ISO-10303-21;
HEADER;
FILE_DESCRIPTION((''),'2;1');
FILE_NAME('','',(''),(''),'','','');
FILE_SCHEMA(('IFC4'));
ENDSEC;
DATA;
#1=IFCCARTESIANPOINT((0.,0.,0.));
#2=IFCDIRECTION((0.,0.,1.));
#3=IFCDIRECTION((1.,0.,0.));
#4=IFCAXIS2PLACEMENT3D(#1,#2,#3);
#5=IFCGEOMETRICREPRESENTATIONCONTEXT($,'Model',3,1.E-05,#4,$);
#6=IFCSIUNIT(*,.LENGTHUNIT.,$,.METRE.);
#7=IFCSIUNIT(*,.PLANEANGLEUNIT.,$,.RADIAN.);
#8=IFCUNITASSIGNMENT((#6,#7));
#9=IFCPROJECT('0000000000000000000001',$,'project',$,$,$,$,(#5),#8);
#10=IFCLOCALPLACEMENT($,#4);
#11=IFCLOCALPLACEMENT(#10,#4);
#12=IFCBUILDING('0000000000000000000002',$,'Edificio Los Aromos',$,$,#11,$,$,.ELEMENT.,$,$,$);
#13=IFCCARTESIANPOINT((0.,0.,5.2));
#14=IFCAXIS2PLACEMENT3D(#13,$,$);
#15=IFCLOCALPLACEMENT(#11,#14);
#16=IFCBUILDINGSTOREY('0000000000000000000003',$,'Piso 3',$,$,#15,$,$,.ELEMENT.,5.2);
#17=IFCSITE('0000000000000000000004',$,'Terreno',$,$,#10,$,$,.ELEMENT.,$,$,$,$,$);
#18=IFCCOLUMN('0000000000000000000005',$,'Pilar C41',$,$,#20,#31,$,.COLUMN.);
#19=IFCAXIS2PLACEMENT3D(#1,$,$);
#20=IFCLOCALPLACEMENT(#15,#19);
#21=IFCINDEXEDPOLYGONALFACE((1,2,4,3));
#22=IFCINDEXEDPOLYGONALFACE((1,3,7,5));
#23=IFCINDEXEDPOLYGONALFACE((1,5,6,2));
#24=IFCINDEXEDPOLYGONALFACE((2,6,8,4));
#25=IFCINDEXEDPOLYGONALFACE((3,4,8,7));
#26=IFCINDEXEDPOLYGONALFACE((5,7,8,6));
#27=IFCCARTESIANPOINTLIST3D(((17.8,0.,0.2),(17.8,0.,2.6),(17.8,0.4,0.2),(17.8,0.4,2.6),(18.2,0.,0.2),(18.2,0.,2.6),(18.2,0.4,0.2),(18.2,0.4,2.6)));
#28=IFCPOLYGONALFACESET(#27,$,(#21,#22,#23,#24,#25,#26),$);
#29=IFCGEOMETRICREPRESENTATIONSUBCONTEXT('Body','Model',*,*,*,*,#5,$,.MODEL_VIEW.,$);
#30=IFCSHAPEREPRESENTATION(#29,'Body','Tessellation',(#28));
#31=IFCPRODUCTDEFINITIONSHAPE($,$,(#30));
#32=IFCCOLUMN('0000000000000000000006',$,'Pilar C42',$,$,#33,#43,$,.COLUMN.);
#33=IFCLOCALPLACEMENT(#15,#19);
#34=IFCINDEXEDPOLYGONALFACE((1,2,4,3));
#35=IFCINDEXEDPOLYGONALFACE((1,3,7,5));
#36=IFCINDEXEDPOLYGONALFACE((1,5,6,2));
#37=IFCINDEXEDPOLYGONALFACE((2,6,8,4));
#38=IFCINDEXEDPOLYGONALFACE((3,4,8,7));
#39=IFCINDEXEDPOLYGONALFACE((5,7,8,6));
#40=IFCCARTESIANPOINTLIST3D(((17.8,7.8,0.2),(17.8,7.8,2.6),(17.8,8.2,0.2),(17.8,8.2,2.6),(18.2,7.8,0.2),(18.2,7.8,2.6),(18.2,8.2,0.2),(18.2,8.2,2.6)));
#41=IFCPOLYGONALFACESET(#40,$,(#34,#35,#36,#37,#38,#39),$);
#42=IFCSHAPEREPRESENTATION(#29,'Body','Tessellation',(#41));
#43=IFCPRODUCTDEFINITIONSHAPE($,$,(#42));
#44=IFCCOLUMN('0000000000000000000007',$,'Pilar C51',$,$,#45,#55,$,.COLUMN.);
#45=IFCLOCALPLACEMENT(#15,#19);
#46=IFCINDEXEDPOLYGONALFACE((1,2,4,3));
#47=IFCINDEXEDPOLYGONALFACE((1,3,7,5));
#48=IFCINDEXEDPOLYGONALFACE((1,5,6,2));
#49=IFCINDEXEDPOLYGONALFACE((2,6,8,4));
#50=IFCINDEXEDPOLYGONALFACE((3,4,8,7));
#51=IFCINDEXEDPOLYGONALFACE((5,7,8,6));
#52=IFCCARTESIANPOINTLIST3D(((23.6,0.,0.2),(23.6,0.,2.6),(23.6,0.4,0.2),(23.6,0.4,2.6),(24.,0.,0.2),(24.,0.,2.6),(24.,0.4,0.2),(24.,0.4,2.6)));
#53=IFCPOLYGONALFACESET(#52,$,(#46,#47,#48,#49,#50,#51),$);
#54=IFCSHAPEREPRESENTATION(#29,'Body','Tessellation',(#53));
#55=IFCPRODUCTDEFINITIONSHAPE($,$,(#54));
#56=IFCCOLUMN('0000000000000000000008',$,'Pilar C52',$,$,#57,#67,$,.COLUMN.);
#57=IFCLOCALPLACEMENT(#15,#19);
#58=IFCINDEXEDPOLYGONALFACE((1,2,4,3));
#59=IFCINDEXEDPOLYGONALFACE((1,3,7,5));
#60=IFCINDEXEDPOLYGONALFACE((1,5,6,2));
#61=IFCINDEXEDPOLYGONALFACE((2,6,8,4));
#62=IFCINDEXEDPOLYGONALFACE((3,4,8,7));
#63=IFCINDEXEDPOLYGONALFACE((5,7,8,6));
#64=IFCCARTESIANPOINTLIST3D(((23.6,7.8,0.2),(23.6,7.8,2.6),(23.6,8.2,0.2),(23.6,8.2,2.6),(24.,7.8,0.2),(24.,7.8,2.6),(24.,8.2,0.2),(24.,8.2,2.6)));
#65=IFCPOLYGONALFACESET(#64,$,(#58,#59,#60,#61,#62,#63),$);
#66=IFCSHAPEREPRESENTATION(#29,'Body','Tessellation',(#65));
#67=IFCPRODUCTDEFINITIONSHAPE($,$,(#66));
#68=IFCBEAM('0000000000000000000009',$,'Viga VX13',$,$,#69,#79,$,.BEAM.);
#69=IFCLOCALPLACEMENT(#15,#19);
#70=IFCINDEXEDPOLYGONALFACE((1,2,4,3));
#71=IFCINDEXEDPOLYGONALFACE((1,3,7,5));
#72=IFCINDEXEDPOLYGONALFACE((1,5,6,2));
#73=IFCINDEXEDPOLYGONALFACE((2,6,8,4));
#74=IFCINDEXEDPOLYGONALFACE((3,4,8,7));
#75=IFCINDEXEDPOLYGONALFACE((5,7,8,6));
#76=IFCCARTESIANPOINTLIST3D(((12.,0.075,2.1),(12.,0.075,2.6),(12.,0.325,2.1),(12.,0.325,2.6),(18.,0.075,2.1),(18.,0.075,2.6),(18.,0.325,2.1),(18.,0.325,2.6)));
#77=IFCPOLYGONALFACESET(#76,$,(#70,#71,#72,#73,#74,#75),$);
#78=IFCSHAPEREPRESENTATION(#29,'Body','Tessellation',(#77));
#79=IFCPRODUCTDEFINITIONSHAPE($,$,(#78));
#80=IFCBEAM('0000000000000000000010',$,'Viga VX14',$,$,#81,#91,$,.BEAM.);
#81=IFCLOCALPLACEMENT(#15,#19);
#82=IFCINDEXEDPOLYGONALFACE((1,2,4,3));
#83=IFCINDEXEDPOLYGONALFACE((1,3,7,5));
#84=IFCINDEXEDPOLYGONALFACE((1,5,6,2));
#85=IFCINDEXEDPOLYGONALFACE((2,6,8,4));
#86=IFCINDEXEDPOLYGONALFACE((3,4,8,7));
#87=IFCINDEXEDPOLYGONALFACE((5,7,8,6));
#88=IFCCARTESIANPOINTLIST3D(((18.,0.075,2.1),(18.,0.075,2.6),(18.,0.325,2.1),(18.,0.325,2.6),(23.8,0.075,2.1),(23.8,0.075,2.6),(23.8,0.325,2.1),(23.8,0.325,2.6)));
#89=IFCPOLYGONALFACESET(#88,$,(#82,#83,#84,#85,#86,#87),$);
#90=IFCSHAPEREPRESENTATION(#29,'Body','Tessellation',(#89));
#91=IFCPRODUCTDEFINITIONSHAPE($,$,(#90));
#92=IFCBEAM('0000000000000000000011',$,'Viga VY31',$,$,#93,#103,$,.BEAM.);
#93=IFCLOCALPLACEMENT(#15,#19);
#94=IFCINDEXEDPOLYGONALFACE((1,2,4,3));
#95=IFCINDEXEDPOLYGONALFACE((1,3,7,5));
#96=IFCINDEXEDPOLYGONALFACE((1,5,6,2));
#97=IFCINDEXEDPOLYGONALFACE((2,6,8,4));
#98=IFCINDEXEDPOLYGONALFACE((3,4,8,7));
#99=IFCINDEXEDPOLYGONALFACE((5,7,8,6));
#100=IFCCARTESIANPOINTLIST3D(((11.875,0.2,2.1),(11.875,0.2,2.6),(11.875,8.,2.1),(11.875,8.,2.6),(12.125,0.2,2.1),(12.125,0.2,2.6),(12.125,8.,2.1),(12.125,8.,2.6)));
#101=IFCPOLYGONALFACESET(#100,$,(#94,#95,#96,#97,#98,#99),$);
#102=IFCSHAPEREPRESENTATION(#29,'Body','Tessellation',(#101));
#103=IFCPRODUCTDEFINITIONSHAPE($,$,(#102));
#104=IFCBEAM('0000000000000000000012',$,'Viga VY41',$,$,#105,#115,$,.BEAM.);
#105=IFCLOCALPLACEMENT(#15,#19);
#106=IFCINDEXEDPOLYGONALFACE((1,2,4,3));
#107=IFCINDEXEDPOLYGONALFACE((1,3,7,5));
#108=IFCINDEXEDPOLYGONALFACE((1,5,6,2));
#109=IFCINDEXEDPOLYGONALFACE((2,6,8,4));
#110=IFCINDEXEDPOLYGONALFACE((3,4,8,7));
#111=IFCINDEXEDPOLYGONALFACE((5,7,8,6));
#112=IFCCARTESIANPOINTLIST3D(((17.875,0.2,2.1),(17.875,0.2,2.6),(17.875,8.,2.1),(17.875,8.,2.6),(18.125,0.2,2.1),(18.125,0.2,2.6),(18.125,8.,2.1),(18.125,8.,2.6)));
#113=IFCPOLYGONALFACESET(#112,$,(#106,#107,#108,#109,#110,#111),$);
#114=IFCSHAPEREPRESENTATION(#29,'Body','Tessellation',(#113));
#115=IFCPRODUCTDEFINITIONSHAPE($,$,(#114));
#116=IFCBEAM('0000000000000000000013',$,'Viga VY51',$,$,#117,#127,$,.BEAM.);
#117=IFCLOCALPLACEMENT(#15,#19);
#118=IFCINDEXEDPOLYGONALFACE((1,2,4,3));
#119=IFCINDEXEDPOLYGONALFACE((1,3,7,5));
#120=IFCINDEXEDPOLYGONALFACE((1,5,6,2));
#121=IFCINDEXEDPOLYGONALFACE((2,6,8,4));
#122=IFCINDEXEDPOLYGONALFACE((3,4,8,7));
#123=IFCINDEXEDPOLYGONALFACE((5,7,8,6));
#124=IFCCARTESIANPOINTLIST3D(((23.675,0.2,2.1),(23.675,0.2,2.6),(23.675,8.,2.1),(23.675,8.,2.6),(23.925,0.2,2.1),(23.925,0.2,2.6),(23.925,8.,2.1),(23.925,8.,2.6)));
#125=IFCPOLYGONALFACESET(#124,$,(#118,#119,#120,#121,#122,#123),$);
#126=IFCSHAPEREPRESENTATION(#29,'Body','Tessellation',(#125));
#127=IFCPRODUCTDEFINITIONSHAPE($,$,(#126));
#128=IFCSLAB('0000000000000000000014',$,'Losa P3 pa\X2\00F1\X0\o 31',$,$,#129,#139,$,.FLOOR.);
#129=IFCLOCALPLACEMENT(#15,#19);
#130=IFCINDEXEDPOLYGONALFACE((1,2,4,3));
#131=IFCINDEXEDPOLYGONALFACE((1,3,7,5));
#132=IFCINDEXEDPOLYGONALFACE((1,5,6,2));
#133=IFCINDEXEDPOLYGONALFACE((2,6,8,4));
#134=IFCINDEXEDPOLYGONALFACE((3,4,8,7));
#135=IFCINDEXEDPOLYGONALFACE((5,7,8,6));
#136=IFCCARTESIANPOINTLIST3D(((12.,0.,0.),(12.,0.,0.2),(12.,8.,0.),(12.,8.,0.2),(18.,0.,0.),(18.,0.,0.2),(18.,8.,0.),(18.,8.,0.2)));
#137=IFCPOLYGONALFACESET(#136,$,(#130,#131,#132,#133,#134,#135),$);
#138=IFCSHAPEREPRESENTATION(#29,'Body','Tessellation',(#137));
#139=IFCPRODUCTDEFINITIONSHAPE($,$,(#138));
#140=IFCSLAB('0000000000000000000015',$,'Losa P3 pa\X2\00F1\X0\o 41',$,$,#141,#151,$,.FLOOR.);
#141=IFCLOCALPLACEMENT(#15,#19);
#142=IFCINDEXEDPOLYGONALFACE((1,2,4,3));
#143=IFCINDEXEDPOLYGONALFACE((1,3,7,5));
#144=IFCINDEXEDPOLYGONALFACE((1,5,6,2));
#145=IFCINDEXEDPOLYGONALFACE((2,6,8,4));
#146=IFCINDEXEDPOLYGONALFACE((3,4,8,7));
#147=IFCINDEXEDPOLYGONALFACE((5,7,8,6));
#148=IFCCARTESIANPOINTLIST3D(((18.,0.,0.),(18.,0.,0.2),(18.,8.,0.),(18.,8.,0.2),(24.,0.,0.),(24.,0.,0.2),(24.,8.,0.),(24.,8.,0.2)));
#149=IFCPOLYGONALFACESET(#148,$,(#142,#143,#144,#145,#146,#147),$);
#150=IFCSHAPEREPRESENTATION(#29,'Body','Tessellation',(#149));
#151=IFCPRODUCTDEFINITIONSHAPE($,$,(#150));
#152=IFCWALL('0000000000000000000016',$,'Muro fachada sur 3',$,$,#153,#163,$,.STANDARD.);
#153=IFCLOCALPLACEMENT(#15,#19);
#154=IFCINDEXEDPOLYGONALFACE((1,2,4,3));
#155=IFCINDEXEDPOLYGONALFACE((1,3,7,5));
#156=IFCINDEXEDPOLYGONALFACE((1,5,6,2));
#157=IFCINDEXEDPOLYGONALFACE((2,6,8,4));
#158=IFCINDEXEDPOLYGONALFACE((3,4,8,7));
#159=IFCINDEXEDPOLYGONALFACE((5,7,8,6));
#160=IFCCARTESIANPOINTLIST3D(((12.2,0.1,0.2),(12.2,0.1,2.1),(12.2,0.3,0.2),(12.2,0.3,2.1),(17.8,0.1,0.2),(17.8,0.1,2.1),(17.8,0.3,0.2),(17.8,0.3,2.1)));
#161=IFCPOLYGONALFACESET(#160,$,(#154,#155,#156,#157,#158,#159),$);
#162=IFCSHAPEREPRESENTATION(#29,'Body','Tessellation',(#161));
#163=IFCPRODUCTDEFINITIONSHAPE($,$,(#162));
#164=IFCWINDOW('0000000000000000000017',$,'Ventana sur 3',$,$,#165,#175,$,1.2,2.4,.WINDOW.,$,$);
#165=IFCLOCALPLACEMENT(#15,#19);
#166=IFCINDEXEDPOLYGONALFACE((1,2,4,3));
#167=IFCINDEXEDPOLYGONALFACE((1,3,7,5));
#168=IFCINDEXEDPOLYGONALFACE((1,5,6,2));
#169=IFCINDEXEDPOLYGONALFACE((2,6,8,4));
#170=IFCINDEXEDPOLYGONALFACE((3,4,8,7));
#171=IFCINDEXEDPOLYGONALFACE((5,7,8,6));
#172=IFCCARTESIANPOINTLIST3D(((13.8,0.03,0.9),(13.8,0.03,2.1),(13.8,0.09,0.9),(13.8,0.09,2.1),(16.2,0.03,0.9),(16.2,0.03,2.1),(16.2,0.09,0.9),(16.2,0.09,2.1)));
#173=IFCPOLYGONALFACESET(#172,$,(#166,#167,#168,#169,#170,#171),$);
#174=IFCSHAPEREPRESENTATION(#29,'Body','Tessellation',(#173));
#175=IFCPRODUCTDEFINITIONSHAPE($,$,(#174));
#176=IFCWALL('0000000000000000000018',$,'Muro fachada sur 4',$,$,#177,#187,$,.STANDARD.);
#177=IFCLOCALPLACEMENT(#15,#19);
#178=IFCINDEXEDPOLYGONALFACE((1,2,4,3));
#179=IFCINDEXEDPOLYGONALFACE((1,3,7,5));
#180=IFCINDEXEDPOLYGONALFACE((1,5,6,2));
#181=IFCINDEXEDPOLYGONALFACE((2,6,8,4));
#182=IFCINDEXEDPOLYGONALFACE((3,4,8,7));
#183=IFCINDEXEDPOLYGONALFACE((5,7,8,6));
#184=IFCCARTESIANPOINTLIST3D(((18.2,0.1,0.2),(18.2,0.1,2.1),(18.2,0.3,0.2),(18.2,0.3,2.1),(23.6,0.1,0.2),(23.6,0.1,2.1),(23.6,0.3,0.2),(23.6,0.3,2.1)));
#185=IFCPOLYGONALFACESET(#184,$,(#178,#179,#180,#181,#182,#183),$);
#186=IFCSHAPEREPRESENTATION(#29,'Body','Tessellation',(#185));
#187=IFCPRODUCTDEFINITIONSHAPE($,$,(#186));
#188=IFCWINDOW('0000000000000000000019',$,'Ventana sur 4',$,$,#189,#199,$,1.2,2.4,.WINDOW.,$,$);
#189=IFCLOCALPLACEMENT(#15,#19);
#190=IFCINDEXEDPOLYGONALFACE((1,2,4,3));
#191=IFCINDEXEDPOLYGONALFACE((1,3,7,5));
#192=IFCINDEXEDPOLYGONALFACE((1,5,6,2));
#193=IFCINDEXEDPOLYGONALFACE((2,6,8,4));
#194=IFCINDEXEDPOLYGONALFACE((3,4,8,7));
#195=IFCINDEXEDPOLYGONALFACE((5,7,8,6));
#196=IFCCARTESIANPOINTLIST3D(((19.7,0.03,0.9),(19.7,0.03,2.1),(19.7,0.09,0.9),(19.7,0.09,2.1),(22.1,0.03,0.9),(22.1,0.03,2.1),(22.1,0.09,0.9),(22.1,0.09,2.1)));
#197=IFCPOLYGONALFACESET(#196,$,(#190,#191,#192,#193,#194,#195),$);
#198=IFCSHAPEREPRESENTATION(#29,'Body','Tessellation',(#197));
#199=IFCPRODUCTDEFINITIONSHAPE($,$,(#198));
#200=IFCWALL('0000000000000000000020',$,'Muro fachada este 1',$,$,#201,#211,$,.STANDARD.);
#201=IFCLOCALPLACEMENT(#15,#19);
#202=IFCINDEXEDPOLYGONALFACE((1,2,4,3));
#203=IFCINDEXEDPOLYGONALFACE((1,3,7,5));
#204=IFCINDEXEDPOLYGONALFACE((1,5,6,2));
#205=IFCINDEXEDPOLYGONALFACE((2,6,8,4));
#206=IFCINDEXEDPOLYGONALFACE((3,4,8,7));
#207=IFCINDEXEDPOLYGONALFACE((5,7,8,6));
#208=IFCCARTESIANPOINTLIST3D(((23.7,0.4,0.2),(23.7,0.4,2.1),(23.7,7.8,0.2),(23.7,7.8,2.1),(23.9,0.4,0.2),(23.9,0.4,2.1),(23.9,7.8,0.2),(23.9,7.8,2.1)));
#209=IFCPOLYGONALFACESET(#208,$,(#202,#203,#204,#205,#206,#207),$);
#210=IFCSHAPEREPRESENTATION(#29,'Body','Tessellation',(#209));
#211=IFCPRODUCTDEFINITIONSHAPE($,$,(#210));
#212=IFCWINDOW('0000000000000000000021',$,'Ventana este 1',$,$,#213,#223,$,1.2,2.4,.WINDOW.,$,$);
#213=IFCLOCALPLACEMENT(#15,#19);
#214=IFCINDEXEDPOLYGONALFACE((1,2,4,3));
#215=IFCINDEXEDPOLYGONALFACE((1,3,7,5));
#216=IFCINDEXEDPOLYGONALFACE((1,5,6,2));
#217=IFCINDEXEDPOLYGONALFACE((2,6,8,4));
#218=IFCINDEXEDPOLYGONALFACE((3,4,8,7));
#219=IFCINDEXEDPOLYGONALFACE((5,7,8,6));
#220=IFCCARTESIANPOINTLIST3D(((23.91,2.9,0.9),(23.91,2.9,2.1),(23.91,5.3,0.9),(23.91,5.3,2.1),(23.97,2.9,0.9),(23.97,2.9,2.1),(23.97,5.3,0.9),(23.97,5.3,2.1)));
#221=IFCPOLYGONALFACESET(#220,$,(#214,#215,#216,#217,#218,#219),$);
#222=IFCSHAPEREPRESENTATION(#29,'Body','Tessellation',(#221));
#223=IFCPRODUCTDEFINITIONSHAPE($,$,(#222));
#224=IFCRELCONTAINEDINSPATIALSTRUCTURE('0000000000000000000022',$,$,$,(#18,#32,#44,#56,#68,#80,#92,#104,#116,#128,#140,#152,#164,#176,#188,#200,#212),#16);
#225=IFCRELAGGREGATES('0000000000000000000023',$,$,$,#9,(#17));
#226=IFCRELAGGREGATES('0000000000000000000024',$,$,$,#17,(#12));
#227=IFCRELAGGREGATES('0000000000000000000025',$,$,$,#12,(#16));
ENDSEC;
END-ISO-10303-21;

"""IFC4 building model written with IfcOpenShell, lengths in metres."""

from ifc_helpers import new_model, si_unit, frame, frame_2d, origin_with_axes, place, context, subcontext, project, spatial, rectangle, extrude, element, save


model = new_model("IFC4")

# Units and contexts
model_context = context("Model", 3, precision=1e-05, world=origin_with_axes())
body_context = subcontext(model_context, "Body", "Model", "MODEL_VIEW")
ifc_project = project(units=[si_unit("LENGTHUNIT", "METRE"), si_unit("PLANEANGLEUNIT", "RADIAN")], contexts=[model_context])

# Site, building, storey
site_placement = place(None, origin_with_axes())
site = spatial("IfcSite", under=ifc_project, at=site_placement, Name="Terreno", CompositionType="ELEMENT")
building_placement = place(site_placement, origin_with_axes())
building = spatial("IfcBuilding", under=site, at=building_placement, Name="Edificio Los Aromos", CompositionType="ELEMENT")
storey_placement = place(building_placement, frame((0.0, 0.0, 5.2)))
storey = spatial("IfcBuildingStorey", under=building, at=storey_placement, Name="Piso 3", CompositionType="ELEMENT", Elevation=5.2)

# Columns
for number, where, name in (
    (1, (17.8, 0.0, 0.2), "Pilar C41"),
    (2, (17.8, 7.8, 0.2), "Pilar C42"),
    (3, (23.6, 0.0, 0.2), "Pilar C51"),
    (4, (23.6, 7.8, 0.2), "Pilar C52"),
):
    element("IfcColumn", number, at=place(storey_placement, frame(where)), inside=storey, Name=name, PredefinedType="COLUMN", context=body_context, shape_type="SweptSolid", body=[
        extrude(rectangle(XDim=0.4, YDim=0.4, at=frame_2d((0.2, 0.2))), origin_with_axes(), (0.0, 0.0, 1.0), 2.4),
    ])

# Beams
beam_1_placement = place(storey_placement, frame((12.0, 0.075, 2.1)))
element("IfcBeam", 5, at=beam_1_placement, inside=storey, Name="Viga VX13", PredefinedType="BEAM", context=body_context, shape_type="SweptSolid", body=[
    extrude(rectangle(XDim=6.0, YDim=0.25, at=frame_2d((3.0, 0.125))), origin_with_axes(), (0.0, 0.0, 1.0), 0.5),
])
beam_2_placement = place(storey_placement, frame((18.0, 0.075, 2.1)))
element("IfcBeam", 6, at=beam_2_placement, inside=storey, Name="Viga VX14", PredefinedType="BEAM", context=body_context, shape_type="SweptSolid", body=[
    extrude(rectangle(XDim=5.8, YDim=0.25, at=frame_2d((2.9, 0.125))), origin_with_axes(), (0.0, 0.0, 1.0), 0.5),
])
for number, where, name in (
    (7, (11.875, 0.2, 2.1), "Viga VY31"),
    (8, (17.875, 0.2, 2.1), "Viga VY41"),
    (9, (23.675, 0.2, 2.1), "Viga VY51"),
):
    element("IfcBeam", number, at=place(storey_placement, frame(where)), inside=storey, Name=name, PredefinedType="BEAM", context=body_context, shape_type="SweptSolid", body=[
        extrude(rectangle(XDim=0.25, YDim=7.8, at=frame_2d((0.125, 3.9))), origin_with_axes(), (0.0, 0.0, 1.0), 0.5),
    ])

# Slabs
for number, where, name in (
    (10, (12.0, 0.0, 0.0), "Losa P3 paño 31"),
    (11, (18.0, 0.0, 0.0), "Losa P3 paño 41"),
):
    element("IfcSlab", number, at=place(storey_placement, frame(where)), inside=storey, Name=name, PredefinedType="FLOOR", context=body_context, shape_type="SweptSolid", body=[
        extrude(rectangle(XDim=6.0, YDim=8.0, at=frame_2d((3.0, 4.0))), origin_with_axes(), (0.0, 0.0, 1.0), 0.2),
    ])

# Wall
wall_1_placement = place(storey_placement, frame((12.2, 0.1, 0.2)))
element("IfcWall", 12, at=wall_1_placement, inside=storey, Name="Muro fachada sur 3", PredefinedType="STANDARD", context=body_context, shape_type="SweptSolid", body=[
    extrude(rectangle(XDim=5.6, YDim=0.2, at=frame_2d((2.8, 0.1))), origin_with_axes(), (0.0, 0.0, 1.0), 1.9),
])

# Window
window_1_placement = place(storey_placement, frame((13.8, 0.03, 0.9)))
element("IfcWindow", 13, at=window_1_placement, inside=storey, Name="Ventana sur 3", OverallHeight=1.2, OverallWidth=2.4, PredefinedType="WINDOW", context=body_context, shape_type="SweptSolid", body=[
    extrude(rectangle(XDim=2.4, YDim=0.06, at=frame_2d((1.2, 0.03))), origin_with_axes(), (0.0, 0.0, 1.0), 1.2),
])

# Wall
wall_2_placement = place(storey_placement, frame((18.2, 0.1, 0.2)))
element("IfcWall", 14, at=wall_2_placement, inside=storey, Name="Muro fachada sur 4", PredefinedType="STANDARD", context=body_context, shape_type="SweptSolid", body=[
    extrude(rectangle(XDim=5.4, YDim=0.2, at=frame_2d((2.7, 0.1))), origin_with_axes(), (0.0, 0.0, 1.0), 1.9),
])

# Window
window_2_placement = place(storey_placement, frame((19.7, 0.03, 0.9)))
element("IfcWindow", 15, at=window_2_placement, inside=storey, Name="Ventana sur 4", OverallHeight=1.2, OverallWidth=2.4, PredefinedType="WINDOW", context=body_context, shape_type="SweptSolid", body=[
    extrude(rectangle(XDim=2.4, YDim=0.06, at=frame_2d((1.2, 0.03))), origin_with_axes(), (0.0, 0.0, 1.0), 1.2),
])

# Wall
wall_3_placement = place(storey_placement, frame((23.7, 0.4, 0.2)))
element("IfcWall", 16, at=wall_3_placement, inside=storey, Name="Muro fachada este 1", PredefinedType="STANDARD", context=body_context, shape_type="SweptSolid", body=[
    extrude(rectangle(XDim=0.2, YDim=7.4, at=frame_2d((0.1, 3.7))), origin_with_axes(), (0.0, 0.0, 1.0), 1.9),
])

# Window
window_3_placement = place(storey_placement, frame((23.91, 2.9, 0.9)))
element("IfcWindow", 17, at=window_3_placement, inside=storey, Name="Ventana este 1", OverallHeight=1.2, OverallWidth=2.4, PredefinedType="WINDOW", context=body_context, shape_type="SweptSolid", body=[
    extrude(rectangle(XDim=0.06, YDim=2.4, at=frame_2d((0.03, 1.2))), origin_with_axes(), (0.0, 0.0, 1.0), 1.2),
])

save(model, "model.ifc")
